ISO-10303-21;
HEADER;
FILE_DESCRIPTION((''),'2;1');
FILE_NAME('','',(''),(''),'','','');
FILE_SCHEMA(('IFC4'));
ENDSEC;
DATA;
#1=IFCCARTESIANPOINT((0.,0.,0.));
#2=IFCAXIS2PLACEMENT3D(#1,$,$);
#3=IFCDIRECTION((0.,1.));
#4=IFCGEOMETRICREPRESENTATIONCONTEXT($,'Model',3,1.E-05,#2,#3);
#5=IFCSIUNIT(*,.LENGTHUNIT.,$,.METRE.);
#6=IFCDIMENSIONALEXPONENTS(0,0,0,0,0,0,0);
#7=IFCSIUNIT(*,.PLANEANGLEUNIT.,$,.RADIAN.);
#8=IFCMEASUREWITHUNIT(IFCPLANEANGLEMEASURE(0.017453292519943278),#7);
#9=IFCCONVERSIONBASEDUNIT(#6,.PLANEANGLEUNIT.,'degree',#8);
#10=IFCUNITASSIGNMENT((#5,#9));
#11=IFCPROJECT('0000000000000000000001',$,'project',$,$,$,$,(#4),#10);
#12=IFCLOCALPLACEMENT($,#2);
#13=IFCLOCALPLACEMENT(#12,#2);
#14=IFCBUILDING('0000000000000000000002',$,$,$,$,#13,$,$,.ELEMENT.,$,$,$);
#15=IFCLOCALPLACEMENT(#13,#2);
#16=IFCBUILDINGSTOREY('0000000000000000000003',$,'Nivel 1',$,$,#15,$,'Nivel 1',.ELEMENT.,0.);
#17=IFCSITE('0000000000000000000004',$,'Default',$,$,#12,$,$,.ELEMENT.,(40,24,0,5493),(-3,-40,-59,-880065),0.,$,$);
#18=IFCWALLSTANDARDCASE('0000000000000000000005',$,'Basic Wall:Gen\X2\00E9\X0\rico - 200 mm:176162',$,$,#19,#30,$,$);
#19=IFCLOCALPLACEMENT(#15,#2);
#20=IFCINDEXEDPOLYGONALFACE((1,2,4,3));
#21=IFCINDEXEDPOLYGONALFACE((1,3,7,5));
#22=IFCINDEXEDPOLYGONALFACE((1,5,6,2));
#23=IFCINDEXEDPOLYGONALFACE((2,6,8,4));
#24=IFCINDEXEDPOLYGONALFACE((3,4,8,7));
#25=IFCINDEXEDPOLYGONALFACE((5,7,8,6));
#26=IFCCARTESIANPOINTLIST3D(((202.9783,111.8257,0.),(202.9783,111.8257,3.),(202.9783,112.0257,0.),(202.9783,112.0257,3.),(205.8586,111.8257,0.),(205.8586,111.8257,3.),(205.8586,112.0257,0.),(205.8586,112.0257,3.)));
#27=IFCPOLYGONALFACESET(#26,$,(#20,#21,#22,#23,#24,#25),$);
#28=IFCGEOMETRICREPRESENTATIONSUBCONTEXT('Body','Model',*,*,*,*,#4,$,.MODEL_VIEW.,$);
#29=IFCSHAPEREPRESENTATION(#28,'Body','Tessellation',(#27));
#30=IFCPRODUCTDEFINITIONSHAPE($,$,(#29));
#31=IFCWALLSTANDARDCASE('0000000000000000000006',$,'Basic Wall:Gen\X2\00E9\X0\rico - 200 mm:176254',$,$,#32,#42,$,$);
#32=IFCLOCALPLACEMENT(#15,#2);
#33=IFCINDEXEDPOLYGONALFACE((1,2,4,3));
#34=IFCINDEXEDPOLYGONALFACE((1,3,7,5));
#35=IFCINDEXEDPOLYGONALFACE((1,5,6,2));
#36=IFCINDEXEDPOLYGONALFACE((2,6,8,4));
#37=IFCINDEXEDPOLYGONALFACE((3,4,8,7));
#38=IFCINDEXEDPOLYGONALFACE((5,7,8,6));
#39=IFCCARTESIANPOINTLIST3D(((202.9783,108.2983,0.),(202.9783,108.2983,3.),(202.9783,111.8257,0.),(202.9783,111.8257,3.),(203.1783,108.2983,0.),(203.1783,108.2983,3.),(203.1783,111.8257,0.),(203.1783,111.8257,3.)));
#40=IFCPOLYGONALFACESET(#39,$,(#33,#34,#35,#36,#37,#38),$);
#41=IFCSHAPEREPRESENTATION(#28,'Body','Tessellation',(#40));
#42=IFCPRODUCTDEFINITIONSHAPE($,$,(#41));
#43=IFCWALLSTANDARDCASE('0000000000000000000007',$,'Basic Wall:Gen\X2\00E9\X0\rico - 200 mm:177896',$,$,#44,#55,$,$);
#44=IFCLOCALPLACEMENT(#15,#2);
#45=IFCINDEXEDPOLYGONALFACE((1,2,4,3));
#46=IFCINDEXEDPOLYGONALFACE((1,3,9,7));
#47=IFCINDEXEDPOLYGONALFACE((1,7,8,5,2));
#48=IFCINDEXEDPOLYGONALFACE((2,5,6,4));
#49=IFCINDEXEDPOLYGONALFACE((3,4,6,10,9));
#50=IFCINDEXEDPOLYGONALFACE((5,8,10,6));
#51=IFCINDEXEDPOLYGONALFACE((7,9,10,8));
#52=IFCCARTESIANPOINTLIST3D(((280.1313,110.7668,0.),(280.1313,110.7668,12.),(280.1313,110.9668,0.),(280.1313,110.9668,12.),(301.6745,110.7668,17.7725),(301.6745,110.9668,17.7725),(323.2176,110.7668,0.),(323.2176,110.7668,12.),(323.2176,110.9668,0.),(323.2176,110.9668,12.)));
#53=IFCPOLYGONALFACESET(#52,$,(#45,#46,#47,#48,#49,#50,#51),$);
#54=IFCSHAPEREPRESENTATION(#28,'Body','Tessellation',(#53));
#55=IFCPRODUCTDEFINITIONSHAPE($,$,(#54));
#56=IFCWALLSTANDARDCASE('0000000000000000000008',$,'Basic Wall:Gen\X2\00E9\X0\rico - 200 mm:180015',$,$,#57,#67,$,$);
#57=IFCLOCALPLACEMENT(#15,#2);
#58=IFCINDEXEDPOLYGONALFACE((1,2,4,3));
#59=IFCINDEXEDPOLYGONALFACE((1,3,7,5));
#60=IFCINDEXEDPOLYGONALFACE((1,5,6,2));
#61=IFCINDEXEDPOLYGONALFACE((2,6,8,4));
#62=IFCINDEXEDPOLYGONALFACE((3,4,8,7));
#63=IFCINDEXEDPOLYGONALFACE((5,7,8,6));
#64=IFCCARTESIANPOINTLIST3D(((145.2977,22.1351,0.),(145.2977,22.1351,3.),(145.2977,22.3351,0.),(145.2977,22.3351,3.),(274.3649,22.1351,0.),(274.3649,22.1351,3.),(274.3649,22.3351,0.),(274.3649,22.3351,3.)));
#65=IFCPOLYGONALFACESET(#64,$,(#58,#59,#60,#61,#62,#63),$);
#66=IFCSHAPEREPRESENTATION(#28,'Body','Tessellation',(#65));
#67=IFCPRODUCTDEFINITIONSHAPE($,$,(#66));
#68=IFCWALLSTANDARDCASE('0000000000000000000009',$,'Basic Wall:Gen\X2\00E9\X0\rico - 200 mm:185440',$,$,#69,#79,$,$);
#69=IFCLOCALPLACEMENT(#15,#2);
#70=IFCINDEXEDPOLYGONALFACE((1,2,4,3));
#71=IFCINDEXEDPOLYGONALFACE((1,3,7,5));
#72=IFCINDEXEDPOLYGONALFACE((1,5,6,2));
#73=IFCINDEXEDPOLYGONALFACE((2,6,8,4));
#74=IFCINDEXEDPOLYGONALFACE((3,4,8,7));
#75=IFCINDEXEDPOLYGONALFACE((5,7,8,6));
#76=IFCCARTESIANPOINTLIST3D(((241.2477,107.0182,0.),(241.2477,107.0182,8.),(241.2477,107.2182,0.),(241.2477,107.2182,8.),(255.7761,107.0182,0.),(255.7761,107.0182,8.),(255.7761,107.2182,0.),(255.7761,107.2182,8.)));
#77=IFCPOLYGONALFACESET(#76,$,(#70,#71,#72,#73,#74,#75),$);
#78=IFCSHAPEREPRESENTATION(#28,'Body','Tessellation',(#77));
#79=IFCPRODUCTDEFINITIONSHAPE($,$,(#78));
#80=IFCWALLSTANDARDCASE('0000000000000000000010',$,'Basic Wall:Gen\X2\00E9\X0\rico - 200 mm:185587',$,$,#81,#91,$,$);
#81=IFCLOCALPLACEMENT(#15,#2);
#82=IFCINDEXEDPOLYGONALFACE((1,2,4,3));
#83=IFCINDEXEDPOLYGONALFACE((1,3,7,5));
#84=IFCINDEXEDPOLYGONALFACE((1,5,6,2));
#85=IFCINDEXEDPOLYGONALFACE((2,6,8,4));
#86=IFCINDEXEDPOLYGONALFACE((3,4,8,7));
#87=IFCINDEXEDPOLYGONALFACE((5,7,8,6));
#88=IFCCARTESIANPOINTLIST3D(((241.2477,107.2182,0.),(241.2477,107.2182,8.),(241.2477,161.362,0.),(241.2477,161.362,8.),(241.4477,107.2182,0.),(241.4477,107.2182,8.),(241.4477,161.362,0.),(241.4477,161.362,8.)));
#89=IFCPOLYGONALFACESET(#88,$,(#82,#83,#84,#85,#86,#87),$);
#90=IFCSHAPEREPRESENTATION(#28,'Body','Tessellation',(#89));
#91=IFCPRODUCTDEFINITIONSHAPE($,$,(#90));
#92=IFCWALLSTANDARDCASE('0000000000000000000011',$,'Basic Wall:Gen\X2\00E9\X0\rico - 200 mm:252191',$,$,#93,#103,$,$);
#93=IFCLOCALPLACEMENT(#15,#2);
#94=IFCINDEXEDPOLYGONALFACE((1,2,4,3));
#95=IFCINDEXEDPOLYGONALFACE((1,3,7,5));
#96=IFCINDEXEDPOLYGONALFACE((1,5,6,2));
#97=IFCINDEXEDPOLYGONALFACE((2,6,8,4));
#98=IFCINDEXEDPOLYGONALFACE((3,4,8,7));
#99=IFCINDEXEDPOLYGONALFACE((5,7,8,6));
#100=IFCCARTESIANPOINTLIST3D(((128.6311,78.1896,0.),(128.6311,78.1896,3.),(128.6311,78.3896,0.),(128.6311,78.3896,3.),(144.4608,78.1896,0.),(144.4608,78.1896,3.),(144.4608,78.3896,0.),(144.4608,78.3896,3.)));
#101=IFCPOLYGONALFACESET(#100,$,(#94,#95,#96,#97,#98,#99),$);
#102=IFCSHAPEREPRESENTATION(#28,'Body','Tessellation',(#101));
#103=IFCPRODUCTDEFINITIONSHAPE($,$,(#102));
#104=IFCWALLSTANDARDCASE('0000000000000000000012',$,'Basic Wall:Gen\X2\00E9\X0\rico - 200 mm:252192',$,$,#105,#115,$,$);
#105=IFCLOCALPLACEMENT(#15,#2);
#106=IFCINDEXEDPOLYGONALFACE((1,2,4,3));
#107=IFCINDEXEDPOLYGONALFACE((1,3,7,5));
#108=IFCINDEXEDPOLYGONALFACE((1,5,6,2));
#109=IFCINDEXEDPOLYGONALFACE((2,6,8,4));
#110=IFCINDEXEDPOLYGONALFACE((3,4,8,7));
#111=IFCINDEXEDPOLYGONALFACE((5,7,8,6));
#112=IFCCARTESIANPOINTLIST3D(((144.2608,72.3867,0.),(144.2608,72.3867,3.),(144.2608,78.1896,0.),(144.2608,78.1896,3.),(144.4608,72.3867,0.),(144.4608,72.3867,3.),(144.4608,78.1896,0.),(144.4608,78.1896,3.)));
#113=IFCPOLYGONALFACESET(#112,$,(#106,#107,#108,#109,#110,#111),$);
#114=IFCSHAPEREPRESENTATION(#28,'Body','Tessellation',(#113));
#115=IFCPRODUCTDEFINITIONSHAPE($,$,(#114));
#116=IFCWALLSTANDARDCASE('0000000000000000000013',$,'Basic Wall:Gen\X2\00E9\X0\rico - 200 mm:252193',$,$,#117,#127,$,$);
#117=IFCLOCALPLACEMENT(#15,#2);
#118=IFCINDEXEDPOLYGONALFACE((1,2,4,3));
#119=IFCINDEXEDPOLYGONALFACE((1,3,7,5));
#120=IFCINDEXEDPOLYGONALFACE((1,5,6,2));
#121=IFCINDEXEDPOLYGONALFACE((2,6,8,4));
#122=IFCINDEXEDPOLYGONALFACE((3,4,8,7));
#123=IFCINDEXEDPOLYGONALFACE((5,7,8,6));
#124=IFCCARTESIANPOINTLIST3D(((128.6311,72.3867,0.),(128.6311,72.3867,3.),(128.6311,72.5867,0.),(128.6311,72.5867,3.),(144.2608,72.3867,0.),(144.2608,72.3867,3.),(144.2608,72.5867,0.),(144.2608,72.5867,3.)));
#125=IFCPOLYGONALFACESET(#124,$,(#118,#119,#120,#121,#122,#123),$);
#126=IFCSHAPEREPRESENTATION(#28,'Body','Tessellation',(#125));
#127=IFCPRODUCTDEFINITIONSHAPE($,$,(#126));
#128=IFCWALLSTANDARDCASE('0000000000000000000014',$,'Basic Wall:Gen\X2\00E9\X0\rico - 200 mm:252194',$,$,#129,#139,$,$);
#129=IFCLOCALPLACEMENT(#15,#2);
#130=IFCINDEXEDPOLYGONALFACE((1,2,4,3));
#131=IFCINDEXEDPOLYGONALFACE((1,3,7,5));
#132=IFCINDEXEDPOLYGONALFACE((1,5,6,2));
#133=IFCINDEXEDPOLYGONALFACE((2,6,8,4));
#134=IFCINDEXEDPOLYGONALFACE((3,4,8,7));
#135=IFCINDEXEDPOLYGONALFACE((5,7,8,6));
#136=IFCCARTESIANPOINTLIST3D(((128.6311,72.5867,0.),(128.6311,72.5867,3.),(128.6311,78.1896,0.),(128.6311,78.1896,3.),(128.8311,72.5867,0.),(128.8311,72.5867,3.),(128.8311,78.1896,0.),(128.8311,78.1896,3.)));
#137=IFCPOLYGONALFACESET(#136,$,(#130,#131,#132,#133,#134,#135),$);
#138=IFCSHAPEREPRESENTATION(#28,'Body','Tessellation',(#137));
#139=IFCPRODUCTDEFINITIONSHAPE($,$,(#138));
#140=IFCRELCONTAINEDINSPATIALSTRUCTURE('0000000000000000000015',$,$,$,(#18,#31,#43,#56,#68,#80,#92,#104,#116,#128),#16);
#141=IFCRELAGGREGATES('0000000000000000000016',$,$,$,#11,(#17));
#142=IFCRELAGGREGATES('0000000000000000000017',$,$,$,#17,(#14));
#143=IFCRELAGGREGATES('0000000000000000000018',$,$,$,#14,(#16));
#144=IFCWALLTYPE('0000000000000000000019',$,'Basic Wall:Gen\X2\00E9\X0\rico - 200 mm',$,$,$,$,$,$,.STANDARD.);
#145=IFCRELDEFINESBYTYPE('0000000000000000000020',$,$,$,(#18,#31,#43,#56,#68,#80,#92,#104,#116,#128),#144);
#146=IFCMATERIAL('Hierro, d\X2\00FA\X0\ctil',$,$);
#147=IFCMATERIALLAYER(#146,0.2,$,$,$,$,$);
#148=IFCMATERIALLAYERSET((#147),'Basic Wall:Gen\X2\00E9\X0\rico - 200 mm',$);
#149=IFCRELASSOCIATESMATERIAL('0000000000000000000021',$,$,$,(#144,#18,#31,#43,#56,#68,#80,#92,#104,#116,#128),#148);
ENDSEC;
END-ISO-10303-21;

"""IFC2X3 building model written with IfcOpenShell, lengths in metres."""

from ifc_helpers import new_model, entity, si_unit, converted_unit, direction, frame, frame_2d, origin, place, context, subcontext, project, spatial, polyline, rectangle, extrude, clip, bounded_halfspace, material, layer, layer_set, layer_usage, type_object, element, save


model = new_model("IFC2X3")

# Units and contexts
model_context = context("Model", 3, precision=1e-05, world=origin(), true_north=direction((0.0, 1.0)))
body_context = subcontext(model_context, "Body", "Model", "MODEL_VIEW")
ifc_project = project(units=[si_unit("LENGTHUNIT", "METRE"), converted_unit("PLANEANGLEUNIT", "degree", entity("IfcPlaneAngleMeasure", 0.017453292519943278), si_unit("PLANEANGLEUNIT", "RADIAN"), dimensions=[0, 0, 0, 0, 0, 0, 0])], contexts=[model_context])

# Site, building, storey
site_placement = place(None, origin())
site = spatial("IfcSite", under=ifc_project, at=site_placement, Name="Default", CompositionType="ELEMENT", RefLatitude=(40, 24, 0, 5493), RefLongitude=(-3, -40, -59, -880065), RefElevation=0.0)
building_placement = place(site_placement, origin())
building = spatial("IfcBuilding", under=site, at=building_placement, CompositionType="ELEMENT")
storey_placement = place(building_placement, origin())
storey = spatial("IfcBuildingStorey", under=building, at=storey_placement, Name="Nivel 1", LongName="Nivel 1", CompositionType="ELEMENT", Elevation=0.0)

# Walls
ifc_material_1 = material(Name="Hierro, dúctil")
ifc_layer_1 = layer(ifc_material_1, 0.2)
ifc_layer_set_1 = layer_set([ifc_layer_1], Name="Basic Wall:Genérico - 200 mm")
wall_type = type_object("IfcWallType", Name="Basic Wall:Genérico - 200 mm", PredefinedType="STANDARD", material=ifc_layer_set_1)
ifc_layer_usage_1 = layer_usage(ifc_layer_set_1, "AXIS2", "NEGATIVE", 0.1)
wall_1_placement = place(storey_placement, frame((205.8586, 111.9257, 0.0), z_axis=(0.0, 0.0, 1.0), x_axis=(-1.0, 0.0, 0.0)))
element("IfcWallStandardCase", 1, at=wall_1_placement, inside=storey, type_object=wall_type, material=ifc_layer_usage_1, Name="Basic Wall:Genérico - 200 mm:176162", context=body_context, shape_type="SweptSolid", body=[
    extrude(rectangle(XDim=2.8803, YDim=0.2, at=frame_2d((1.4401, 0.0), x_axis=(-1.0, 0.0))), origin(), (0.0, 0.0, 1.0), 3.0),
])
ifc_layer_usage_2 = layer_usage(ifc_layer_set_1, "AXIS2", "NEGATIVE", 0.1)
wall_2_placement = place(storey_placement, frame((203.0783, 111.8257, 0.0), z_axis=(0.0, 0.0, 1.0), x_axis=(0.0, -1.0, 0.0)))
element("IfcWallStandardCase", 2, at=wall_2_placement, inside=storey, type_object=wall_type, material=ifc_layer_usage_2, Name="Basic Wall:Genérico - 200 mm:176254", context=body_context, shape_type="SweptSolid", body=[
    extrude(rectangle(XDim=3.5274, YDim=0.2, at=frame_2d((1.7637, 0.0), x_axis=(-1.0, 0.0))), origin(), (0.0, 0.0, 1.0), 3.0),
])
ifc_layer_usage_3 = layer_usage(ifc_layer_set_1, "AXIS2", "NEGATIVE", 0.1)
wall_3_placement = place(storey_placement, frame((280.1313, 110.8668, 0.0)))
element("IfcWallStandardCase", 3, at=wall_3_placement, inside=storey, type_object=wall_type, material=ifc_layer_usage_3, Name="Basic Wall:Genérico - 200 mm:177896", context=body_context, shape_type="Clipping", body=[
    clip(clip(extrude(rectangle(XDim=43.0863, YDim=0.2, at=frame_2d((21.5432, 0.0), x_axis=(-1.0, 0.0))), origin(), (0.0, 0.0, 1.0), 17.7725), bounded_halfspace(frame((21.5432, -0.1, 17.7725), z_axis=(0.258819, 0.0, 0.965926), x_axis=(0.0, 1.0, 0.0)), False, frame((21.5432, -0.1, 17.7725)), polyline([(0.0, 0.0), (21.5432, 0.0), (21.5432, 0.2), (0.0, 0.2), (0.0, 0.0)]))), bounded_halfspace(frame((0.0, -0.1, 12.0), z_axis=(-0.258819, 0.0, 0.965926), x_axis=(0.0, -1.0, 0.0)), False, frame((0.0, -0.1, 12.0)), polyline([(0.0, 0.0), (21.5432, 0.0), (21.5432, 0.2), (0.0, 0.2), (0.0, 0.0)]))),
])
ifc_layer_usage_4 = layer_usage(ifc_layer_set_1, "AXIS2", "NEGATIVE", 0.1)
wall_4_placement = place(storey_placement, frame((145.2977, 22.2351, 0.0)))
element("IfcWallStandardCase", 4, at=wall_4_placement, inside=storey, type_object=wall_type, material=ifc_layer_usage_4, Name="Basic Wall:Genérico - 200 mm:180015", context=body_context, shape_type="SweptSolid", body=[
    extrude(rectangle(XDim=129.0672, YDim=0.2, at=frame_2d((64.5336, 0.0), x_axis=(-1.0, 0.0))), origin(), (0.0, 0.0, 1.0), 3.0),
])
ifc_layer_usage_5 = layer_usage(ifc_layer_set_1, "AXIS2", "NEGATIVE", 0.1)
wall_5_placement = place(storey_placement, frame((255.7761, 107.1182, 0.0), z_axis=(0.0, 0.0, 1.0), x_axis=(-1.0, 0.0, 0.0)))
element("IfcWallStandardCase", 5, at=wall_5_placement, inside=storey, type_object=wall_type, material=ifc_layer_usage_5, Name="Basic Wall:Genérico - 200 mm:185440", context=body_context, shape_type="SweptSolid", body=[
    extrude(rectangle(XDim=14.5284, YDim=0.2, at=frame_2d((7.2642, 0.0), x_axis=(-1.0, 0.0))), origin(), (0.0, 0.0, 1.0), 8.0),
])
ifc_layer_usage_6 = layer_usage(ifc_layer_set_1, "AXIS2", "NEGATIVE", 0.1)
wall_6_placement = place(storey_placement, frame((241.3477, 107.2182, 0.0), z_axis=(0.0, 0.0, 1.0), x_axis=(0.0, 1.0, 0.0)))
element("IfcWallStandardCase", 6, at=wall_6_placement, inside=storey, type_object=wall_type, material=ifc_layer_usage_6, Name="Basic Wall:Genérico - 200 mm:185587", context=body_context, shape_type="SweptSolid", body=[
    extrude(rectangle(XDim=54.1438, YDim=0.2, at=frame_2d((27.0719, 0.0), x_axis=(-1.0, 0.0))), origin(), (0.0, 0.0, 1.0), 8.0),
])
ifc_layer_usage_7 = layer_usage(ifc_layer_set_1, "AXIS2", "NEGATIVE", 0.1)
wall_7_placement = place(storey_placement, frame((128.6311, 78.2896, 0.0)))
element("IfcWallStandardCase", 7, at=wall_7_placement, inside=storey, type_object=wall_type, material=ifc_layer_usage_7, Name="Basic Wall:Genérico - 200 mm:252191", context=body_context, shape_type="SweptSolid", body=[
    extrude(rectangle(XDim=15.8297, YDim=0.2, at=frame_2d((7.9148, 0.0), x_axis=(-1.0, 0.0))), origin(), (0.0, 0.0, 1.0), 3.0),
])
ifc_layer_usage_8 = layer_usage(ifc_layer_set_1, "AXIS2", "NEGATIVE", 0.1)
wall_8_placement = place(storey_placement, frame((144.3608, 78.1896, 0.0), z_axis=(0.0, 0.0, 1.0), x_axis=(0.0, -1.0, 0.0)))
element("IfcWallStandardCase", 8, at=wall_8_placement, inside=storey, type_object=wall_type, material=ifc_layer_usage_8, Name="Basic Wall:Genérico - 200 mm:252192", context=body_context, shape_type="SweptSolid", body=[
    extrude(rectangle(XDim=5.8029, YDim=0.2, at=frame_2d((2.9014, 0.0), x_axis=(-1.0, 0.0))), origin(), (0.0, 0.0, 1.0), 3.0),
])
ifc_layer_usage_9 = layer_usage(ifc_layer_set_1, "AXIS2", "NEGATIVE", 0.1)
wall_9_placement = place(storey_placement, frame((144.2608, 72.4867, 0.0), z_axis=(0.0, 0.0, 1.0), x_axis=(-1.0, 0.0, 0.0)))
element("IfcWallStandardCase", 9, at=wall_9_placement, inside=storey, type_object=wall_type, material=ifc_layer_usage_9, Name="Basic Wall:Genérico - 200 mm:252193", context=body_context, shape_type="SweptSolid", body=[
    extrude(rectangle(XDim=15.6297, YDim=0.2, at=frame_2d((7.8148, 0.0), x_axis=(-1.0, 0.0))), origin(), (0.0, 0.0, 1.0), 3.0),
])
ifc_layer_usage_10 = layer_usage(ifc_layer_set_1, "AXIS2", "NEGATIVE", 0.1)
wall_10_placement = place(storey_placement, frame((128.7311, 72.5867, 0.0), z_axis=(0.0, 0.0, 1.0), x_axis=(0.0, 1.0, 0.0)))
element("IfcWallStandardCase", 10, at=wall_10_placement, inside=storey, type_object=wall_type, material=ifc_layer_usage_10, Name="Basic Wall:Genérico - 200 mm:252194", context=body_context, shape_type="SweptSolid", body=[
    extrude(rectangle(XDim=5.6029, YDim=0.2, at=frame_2d((2.8014, 0.0), x_axis=(-1.0, 0.0))), origin(), (0.0, 0.0, 1.0), 3.0),
])

save(model, "model.ifc")
